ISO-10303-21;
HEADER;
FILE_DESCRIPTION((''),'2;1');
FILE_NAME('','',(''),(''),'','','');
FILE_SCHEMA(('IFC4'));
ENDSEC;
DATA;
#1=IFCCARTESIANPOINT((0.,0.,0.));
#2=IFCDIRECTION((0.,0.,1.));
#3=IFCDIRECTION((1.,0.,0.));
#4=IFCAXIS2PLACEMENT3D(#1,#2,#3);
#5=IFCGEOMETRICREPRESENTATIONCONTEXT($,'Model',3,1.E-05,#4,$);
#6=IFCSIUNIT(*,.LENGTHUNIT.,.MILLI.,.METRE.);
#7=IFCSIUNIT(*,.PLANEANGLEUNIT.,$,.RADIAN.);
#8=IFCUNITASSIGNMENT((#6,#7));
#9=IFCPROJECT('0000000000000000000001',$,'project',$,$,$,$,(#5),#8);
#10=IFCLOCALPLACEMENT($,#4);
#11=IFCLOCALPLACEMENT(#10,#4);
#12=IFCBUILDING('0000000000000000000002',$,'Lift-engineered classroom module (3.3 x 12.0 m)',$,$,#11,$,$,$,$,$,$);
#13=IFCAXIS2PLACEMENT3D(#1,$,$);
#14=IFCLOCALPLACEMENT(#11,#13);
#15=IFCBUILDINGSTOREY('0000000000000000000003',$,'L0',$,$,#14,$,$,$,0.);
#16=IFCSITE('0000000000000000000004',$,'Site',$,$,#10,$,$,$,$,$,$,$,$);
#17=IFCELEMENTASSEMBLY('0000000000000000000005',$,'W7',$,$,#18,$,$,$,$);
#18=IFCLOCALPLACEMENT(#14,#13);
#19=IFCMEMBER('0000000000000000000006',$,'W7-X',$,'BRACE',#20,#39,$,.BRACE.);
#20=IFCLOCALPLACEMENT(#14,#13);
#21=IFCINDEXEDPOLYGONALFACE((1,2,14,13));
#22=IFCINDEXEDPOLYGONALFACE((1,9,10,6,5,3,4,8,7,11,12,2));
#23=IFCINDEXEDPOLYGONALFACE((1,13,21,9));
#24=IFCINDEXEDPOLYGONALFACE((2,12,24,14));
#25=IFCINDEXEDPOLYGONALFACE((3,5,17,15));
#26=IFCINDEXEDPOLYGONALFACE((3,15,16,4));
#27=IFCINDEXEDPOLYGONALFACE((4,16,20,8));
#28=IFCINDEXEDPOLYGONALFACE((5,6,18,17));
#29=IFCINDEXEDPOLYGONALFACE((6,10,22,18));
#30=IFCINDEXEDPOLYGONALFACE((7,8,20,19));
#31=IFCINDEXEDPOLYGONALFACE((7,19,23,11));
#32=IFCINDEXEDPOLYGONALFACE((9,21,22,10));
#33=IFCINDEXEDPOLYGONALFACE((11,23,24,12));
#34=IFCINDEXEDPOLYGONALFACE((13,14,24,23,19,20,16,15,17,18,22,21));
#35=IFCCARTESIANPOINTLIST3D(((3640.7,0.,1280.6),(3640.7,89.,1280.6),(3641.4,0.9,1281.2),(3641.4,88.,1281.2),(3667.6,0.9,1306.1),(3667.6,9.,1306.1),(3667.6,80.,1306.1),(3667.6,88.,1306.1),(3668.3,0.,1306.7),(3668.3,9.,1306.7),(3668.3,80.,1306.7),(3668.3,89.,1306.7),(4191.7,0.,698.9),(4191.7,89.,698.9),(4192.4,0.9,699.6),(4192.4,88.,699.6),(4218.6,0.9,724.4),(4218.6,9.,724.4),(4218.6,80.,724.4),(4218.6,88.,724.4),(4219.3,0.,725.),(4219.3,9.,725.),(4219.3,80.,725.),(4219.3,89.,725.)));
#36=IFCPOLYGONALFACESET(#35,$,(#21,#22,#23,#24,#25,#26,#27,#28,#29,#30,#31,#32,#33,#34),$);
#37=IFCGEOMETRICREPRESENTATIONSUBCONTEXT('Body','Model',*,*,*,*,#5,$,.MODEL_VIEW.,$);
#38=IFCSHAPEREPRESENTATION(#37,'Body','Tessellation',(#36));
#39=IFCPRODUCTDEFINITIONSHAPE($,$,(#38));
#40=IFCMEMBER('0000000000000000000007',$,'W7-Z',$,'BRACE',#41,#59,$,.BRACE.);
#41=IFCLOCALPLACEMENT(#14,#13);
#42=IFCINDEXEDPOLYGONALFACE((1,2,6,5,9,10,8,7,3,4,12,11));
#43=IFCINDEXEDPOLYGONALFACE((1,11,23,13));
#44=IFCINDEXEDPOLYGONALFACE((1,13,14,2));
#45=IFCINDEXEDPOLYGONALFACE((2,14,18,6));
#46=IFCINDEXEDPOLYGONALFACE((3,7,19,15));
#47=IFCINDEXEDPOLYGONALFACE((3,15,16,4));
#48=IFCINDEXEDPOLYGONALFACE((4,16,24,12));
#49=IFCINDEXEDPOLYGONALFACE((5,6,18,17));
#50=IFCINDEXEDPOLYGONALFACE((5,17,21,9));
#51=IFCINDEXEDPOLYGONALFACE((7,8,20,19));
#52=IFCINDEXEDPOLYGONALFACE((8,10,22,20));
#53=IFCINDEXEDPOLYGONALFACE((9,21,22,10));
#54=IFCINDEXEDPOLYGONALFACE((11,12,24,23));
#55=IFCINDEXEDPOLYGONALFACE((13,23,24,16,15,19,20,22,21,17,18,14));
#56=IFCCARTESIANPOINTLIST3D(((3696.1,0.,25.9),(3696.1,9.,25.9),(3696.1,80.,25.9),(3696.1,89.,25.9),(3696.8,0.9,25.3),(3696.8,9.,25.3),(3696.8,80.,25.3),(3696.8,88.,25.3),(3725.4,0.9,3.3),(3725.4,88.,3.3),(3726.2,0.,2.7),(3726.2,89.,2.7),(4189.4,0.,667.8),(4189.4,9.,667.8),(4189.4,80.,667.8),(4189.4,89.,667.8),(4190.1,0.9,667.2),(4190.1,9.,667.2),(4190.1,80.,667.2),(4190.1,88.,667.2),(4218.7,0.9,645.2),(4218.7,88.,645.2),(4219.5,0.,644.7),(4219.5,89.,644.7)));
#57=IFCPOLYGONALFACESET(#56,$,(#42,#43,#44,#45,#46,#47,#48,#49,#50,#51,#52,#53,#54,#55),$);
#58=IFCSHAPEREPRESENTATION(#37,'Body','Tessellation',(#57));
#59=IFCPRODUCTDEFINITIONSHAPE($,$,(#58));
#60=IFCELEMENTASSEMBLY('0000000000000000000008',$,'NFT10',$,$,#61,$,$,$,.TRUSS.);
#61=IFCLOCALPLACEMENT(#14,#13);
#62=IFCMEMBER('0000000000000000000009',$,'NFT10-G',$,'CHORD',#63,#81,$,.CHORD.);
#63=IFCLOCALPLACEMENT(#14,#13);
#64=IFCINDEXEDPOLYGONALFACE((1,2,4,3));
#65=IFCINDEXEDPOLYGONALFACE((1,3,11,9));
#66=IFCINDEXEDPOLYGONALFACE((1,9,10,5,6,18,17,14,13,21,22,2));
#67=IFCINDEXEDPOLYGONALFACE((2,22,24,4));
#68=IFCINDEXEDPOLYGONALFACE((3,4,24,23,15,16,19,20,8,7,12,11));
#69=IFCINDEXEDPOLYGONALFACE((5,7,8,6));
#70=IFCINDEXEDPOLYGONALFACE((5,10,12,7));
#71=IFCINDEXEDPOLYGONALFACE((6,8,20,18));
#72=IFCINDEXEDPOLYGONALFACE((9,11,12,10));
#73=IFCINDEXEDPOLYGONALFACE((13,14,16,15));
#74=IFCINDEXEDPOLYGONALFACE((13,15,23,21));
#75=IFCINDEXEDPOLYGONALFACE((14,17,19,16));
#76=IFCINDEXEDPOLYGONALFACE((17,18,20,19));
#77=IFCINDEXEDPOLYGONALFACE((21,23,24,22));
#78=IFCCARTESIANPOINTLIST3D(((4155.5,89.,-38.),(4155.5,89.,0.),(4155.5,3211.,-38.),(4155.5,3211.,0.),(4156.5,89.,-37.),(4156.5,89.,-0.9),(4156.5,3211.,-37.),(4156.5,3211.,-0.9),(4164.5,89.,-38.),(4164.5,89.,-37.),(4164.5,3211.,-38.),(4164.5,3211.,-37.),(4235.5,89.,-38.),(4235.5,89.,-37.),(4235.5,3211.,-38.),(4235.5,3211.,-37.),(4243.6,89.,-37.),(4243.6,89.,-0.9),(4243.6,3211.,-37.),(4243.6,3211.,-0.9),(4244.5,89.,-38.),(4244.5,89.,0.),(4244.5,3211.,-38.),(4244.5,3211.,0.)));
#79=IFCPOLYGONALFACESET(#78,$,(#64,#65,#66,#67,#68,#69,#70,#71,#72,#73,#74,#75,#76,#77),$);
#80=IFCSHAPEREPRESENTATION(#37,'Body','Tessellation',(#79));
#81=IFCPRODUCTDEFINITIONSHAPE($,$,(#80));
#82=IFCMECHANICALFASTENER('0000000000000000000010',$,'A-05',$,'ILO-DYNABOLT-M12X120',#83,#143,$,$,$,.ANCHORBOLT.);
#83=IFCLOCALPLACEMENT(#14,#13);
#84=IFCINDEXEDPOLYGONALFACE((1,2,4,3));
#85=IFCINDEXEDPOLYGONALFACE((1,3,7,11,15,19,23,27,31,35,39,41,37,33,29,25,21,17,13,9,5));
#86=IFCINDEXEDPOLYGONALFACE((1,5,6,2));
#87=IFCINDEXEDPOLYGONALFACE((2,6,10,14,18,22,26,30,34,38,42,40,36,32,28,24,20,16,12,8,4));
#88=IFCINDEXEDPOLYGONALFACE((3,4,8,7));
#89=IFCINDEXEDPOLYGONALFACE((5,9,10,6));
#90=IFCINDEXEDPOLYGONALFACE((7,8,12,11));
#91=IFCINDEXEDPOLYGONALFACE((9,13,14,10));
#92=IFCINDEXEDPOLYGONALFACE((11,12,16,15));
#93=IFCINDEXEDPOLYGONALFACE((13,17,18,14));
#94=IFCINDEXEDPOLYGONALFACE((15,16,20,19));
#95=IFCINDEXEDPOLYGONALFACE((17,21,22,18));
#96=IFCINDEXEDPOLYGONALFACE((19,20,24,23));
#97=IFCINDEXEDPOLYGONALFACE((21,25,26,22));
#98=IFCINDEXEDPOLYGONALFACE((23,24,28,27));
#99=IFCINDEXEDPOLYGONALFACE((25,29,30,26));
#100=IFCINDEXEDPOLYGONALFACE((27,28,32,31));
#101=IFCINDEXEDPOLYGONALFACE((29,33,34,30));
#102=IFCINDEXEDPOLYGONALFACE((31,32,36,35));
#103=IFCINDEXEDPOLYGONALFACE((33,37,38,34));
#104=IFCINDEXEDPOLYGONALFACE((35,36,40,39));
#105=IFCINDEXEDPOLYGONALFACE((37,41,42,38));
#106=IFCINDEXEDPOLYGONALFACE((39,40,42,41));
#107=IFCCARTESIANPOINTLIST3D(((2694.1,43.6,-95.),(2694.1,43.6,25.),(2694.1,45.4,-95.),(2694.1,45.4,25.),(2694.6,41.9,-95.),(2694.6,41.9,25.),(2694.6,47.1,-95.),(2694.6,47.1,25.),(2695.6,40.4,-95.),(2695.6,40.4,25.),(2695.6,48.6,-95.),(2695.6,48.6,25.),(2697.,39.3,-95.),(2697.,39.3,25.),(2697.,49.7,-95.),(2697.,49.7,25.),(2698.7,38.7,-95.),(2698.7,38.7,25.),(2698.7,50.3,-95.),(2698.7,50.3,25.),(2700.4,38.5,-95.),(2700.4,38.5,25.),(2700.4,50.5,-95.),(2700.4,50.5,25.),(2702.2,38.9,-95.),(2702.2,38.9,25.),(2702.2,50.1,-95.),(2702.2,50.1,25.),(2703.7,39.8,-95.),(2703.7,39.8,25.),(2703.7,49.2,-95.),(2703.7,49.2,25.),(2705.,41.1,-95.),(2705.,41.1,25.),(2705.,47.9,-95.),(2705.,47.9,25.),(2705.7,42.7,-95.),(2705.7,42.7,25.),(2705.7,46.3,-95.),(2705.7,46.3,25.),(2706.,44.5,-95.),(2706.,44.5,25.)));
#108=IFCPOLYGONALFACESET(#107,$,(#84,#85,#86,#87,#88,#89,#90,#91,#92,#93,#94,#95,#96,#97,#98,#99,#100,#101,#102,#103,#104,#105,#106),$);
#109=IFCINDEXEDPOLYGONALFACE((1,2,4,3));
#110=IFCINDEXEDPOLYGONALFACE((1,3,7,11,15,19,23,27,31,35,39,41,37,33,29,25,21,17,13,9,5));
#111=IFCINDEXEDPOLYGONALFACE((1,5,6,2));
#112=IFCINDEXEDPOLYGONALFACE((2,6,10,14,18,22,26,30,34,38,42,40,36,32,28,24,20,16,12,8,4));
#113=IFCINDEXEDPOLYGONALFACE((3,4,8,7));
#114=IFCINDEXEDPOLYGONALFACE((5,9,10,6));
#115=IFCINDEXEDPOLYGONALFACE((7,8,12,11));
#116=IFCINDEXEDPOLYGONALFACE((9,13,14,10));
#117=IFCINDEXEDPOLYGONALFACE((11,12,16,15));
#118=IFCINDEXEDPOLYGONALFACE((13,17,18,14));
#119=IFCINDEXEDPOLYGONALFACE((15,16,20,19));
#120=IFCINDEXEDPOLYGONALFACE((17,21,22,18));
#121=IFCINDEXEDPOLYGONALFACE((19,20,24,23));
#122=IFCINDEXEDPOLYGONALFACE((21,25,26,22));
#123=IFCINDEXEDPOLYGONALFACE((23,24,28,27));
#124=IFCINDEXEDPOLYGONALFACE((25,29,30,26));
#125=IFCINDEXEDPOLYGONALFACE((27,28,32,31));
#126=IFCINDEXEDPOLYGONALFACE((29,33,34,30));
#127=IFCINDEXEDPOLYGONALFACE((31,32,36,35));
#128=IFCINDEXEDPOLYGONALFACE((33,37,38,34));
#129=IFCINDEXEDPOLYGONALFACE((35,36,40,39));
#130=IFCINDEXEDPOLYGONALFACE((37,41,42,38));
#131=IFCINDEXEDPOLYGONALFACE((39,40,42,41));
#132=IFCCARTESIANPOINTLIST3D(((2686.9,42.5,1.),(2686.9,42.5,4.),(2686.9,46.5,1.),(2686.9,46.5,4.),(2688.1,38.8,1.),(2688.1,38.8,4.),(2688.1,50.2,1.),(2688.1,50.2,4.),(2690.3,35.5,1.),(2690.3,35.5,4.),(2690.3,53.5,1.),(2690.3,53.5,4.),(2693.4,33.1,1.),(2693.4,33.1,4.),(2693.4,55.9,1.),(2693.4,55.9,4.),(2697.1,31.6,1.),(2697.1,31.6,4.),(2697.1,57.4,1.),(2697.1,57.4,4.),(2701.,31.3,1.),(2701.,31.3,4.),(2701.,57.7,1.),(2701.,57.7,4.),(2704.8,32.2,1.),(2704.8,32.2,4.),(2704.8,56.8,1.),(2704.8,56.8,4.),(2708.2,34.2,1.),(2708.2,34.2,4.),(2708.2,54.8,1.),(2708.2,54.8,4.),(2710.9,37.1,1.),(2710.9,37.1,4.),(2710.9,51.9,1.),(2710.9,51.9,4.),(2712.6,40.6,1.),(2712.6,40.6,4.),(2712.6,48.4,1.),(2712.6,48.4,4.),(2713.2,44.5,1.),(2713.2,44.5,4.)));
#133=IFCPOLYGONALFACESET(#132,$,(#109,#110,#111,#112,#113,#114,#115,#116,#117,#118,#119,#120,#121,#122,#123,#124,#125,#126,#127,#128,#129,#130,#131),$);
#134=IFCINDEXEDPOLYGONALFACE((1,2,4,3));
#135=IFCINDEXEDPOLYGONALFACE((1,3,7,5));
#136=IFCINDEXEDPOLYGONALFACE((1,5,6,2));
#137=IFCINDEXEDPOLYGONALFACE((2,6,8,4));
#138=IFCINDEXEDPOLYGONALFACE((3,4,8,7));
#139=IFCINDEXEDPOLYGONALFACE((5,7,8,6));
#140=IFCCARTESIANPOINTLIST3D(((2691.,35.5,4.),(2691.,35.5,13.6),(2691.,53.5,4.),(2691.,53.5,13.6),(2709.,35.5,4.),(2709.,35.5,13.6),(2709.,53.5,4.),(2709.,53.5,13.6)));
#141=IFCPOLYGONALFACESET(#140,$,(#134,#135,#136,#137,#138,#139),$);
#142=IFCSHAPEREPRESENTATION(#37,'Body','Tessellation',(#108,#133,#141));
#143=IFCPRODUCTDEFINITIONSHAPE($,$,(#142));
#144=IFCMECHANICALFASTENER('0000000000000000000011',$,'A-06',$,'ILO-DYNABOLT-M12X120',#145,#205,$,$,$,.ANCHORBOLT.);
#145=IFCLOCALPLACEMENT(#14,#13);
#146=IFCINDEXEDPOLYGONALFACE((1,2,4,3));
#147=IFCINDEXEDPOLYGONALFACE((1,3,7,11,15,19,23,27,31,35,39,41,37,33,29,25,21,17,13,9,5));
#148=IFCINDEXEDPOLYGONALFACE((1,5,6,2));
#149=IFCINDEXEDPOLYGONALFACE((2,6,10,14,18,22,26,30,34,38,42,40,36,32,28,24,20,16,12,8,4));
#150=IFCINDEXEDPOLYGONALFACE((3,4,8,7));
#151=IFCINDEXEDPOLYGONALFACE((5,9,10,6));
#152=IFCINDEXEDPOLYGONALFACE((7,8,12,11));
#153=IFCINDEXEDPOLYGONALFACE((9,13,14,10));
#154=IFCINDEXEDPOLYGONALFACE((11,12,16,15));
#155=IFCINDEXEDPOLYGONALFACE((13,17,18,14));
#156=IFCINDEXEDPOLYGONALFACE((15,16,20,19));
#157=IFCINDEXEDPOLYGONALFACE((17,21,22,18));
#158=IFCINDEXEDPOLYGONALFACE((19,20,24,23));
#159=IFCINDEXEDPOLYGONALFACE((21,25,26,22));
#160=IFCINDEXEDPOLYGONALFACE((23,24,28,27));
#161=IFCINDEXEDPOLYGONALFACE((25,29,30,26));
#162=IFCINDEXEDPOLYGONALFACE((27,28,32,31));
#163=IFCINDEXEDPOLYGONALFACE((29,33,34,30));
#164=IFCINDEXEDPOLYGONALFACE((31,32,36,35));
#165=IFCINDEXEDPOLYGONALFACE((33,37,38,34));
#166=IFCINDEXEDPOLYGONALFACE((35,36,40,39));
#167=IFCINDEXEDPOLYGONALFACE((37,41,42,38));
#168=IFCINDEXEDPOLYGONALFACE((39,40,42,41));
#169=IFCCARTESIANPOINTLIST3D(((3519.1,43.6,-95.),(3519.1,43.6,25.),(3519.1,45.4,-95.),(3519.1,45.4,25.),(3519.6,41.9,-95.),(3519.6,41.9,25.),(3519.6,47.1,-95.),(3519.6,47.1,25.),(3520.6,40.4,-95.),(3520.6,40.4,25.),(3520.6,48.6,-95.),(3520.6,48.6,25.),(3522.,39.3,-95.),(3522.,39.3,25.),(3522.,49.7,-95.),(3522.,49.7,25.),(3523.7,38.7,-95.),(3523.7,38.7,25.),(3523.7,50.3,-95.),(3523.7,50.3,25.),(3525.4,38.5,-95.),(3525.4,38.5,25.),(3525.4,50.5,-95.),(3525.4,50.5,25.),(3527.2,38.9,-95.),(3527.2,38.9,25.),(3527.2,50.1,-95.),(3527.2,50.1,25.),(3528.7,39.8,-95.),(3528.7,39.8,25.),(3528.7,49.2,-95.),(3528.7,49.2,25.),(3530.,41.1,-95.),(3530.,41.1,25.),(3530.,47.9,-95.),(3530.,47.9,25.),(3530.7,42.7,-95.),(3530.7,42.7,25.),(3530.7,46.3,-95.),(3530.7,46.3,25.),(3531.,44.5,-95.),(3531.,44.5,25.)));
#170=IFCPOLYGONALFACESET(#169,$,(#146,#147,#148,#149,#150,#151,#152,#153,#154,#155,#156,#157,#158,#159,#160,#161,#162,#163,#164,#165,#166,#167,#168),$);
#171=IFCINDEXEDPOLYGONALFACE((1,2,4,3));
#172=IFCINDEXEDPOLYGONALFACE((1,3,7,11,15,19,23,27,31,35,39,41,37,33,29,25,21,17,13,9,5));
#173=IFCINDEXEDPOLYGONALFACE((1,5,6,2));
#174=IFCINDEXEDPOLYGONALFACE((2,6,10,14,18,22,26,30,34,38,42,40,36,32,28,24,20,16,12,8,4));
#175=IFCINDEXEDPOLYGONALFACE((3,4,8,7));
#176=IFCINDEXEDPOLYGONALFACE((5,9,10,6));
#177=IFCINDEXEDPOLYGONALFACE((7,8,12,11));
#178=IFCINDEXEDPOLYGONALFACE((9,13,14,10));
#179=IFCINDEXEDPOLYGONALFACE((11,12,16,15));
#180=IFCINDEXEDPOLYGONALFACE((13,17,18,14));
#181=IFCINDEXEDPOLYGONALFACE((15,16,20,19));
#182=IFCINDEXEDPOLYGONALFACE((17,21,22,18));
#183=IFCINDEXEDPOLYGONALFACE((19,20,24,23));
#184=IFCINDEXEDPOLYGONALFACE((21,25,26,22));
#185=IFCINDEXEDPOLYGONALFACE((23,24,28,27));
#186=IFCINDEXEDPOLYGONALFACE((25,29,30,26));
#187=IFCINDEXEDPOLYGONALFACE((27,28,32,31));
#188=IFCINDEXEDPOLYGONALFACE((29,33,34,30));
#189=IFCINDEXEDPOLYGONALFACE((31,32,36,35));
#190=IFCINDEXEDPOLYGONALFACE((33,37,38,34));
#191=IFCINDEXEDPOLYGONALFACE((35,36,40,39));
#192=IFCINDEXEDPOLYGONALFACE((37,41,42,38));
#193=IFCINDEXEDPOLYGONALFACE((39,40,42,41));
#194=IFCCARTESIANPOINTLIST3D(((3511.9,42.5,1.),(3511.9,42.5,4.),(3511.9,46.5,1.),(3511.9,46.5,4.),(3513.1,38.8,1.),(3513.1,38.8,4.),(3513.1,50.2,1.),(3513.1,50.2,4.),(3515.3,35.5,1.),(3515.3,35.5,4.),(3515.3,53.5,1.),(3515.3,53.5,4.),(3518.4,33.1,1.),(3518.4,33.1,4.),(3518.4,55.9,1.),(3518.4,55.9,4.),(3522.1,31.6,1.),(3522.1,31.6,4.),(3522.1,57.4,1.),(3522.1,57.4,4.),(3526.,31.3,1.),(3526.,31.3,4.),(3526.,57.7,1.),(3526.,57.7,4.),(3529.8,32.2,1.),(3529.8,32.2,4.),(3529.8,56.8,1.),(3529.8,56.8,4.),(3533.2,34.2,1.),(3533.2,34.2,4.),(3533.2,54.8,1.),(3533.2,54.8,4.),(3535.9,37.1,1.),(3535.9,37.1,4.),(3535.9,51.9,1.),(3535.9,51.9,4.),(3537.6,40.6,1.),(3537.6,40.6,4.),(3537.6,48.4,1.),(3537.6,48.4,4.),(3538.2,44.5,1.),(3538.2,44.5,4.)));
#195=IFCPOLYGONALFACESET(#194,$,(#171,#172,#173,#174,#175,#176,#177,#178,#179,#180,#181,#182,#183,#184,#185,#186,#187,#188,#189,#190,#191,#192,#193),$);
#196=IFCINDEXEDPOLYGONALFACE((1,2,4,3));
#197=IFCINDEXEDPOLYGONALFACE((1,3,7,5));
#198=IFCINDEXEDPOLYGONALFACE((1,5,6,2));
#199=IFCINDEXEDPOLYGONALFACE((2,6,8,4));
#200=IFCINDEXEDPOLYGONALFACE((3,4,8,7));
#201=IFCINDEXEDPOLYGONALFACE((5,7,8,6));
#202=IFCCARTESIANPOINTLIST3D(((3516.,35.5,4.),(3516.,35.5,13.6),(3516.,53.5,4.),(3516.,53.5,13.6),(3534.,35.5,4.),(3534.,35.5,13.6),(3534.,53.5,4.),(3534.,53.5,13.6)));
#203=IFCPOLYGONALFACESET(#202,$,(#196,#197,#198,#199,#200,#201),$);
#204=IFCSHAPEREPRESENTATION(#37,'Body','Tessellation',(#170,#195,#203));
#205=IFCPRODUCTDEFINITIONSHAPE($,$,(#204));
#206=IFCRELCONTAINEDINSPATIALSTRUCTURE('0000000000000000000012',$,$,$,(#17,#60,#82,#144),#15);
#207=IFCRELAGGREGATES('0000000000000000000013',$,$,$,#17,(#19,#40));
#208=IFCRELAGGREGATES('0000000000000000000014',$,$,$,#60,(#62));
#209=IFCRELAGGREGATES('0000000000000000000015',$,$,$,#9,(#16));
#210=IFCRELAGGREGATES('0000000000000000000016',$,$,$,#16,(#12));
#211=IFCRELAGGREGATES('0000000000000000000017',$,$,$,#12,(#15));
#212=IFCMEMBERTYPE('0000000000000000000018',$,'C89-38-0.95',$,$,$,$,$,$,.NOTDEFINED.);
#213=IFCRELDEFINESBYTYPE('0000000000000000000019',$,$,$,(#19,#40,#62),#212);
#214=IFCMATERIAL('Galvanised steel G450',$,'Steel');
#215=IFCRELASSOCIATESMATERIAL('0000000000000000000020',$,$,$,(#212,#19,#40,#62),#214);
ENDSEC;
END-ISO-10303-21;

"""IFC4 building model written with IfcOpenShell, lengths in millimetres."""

from ifc_helpers import new_model, si_unit, frame, origin, origin_with_axes, origin_2d, place, context, subcontext, project, spatial, rectangle, circle, c_section, extrude, material, material_profile, profile_set, profile_usage, type_object, element, aggregate, save


model = new_model("IFC4")

# Units and contexts
model_context = context("Model", 3, precision=1e-05, world=origin_with_axes())
body_context = subcontext(model_context, "Body", "Model", "MODEL_VIEW")
ifc_project = project(units=[si_unit("LENGTHUNIT", "METRE", prefix="MILLI"), si_unit("PLANEANGLEUNIT", "RADIAN")], contexts=[model_context])

# Site, building, storey
site_placement = place(None, origin_with_axes())
site = spatial("IfcSite", under=ifc_project, at=site_placement, Name="Site")
building_placement = place(site_placement, origin_with_axes())
building = spatial("IfcBuilding", under=site, at=building_placement, Name="Lift-engineered classroom module (3.3 x 12.0 m)")
storey_placement = place(building_placement, origin())
storey = spatial("IfcBuildingStorey", under=building, at=storey_placement, Name="L0", Elevation=0.0)

# Element assembly, members
assembly_1_placement = place(storey_placement, frame((900.0, 44.5, 0.0)))
assembly_1 = element("IfcElementAssembly", 1, at=assembly_1_placement, inside=storey, Name="W7")
ifc_material = material(Name="Galvanised steel G450", Category="Steel")
ifc_material_profile = material_profile(ifc_material, c_section(Depth=89.0, Width=38.0, WallThickness=0.9, Girth=9.0, at=origin_2d()), Name="C89-38-0.95")
ifc_profile_set = profile_set([ifc_material_profile], Name="C89-38-0.95")
ifc_profile_usage = profile_usage(ifc_profile_set)
member_type = type_object("IfcMemberType", Name="C89-38-0.95", PredefinedType="NOTDEFINED", material=ifc_profile_set)
member_1_placement = place(assembly_1_placement, frame((2754.5, 0.0, 1293.6), z_axis=(0.687721, 0.0, -0.725975), x_axis=(0.725975, 0.0, 0.687721)))
member_1 = element("IfcMember", 2, at=member_1_placement, type_object=member_type, material=ifc_profile_usage, Name="W7-X", ObjectType="BRACE", PredefinedType="BRACE", context=body_context, shape_type="SweptSolid", body=[
    extrude(c_section(Depth=89.0, Width=38.0, WallThickness=0.9, Girth=9.0, at=origin_2d()), origin(), (0.0, 0.0, 1.0), 801.2),
])
member_2_placement = place(assembly_1_placement, frame((2811.1, 0.0, 14.3), z_axis=(0.609305, 0.0, 0.792936), x_axis=(-0.792936, 0.0, 0.609305)))
member_2 = element("IfcMember", 3, at=member_2_placement, type_object=member_type, material=ifc_profile_usage, Name="W7-Z", ObjectType="BRACE", PredefinedType="BRACE", context=body_context, shape_type="SweptSolid", body=[
    extrude(c_section(Depth=89.0, Width=38.0, WallThickness=0.9, Girth=9.0, at=origin_2d()), origin(), (0.0, 0.0, 1.0), 809.6),
])
aggregate(assembly_1, [member_1, member_2])

# Element assembly, member
assembly_2_placement = place(storey_placement, frame((4200.0, 89.0, -300.0)))
assembly_2 = element("IfcElementAssembly", 4, at=assembly_2_placement, inside=storey, Name="NFT10", PredefinedType="TRUSS")
member_3_placement = place(assembly_2_placement, frame((0.0, 0.0, 281.0), z_axis=(0.0, 1.0, 0.0), x_axis=(0.0, 0.0, -1.0)))
member_3 = element("IfcMember", 5, at=member_3_placement, type_object=member_type, material=ifc_profile_usage, Name="NFT10-G", ObjectType="CHORD", PredefinedType="CHORD", context=body_context, shape_type="SweptSolid", body=[
    extrude(c_section(Depth=89.0, Width=38.0, WallThickness=0.9, Girth=9.0, at=origin_2d()), origin(), (0.0, 0.0, 1.0), 3122.0),
])
aggregate(assembly_2, [member_3])

# Mechanical fasteners
for number, where, z_axis, x_axis, name in (
    (6, (2700.0, 44.5, 0.0), (0.0, 0.0, 1.0), (1.0, 0.0, 0.0), "A-05"),
    (7, (3525.0, 44.5, 0.0), (0.0, 0.0, 1.0), (1.0, 0.0, 0.0), "A-06"),
):
    element("IfcMechanicalFastener", number, at=place(None, frame(where, z_axis=z_axis, x_axis=x_axis)), inside=storey, Name=name, ObjectType="ILO-DYNABOLT-M12X120", PredefinedType="ANCHORBOLT", context=body_context, shape_type="SweptSolid", body=[
        extrude(circle(Radius=6.0, at=origin_2d()), frame((0.0, 0.0, -95.0), z_axis=(0.0, 0.0, 1.0), x_axis=(1.0, 0.0, 0.0)), (0.0, 0.0, 1.0), 120.0),
        extrude(circle(Radius=13.2, at=origin_2d()), frame((0.0, 0.0, 1.0), z_axis=(0.0, 0.0, 1.0), x_axis=(1.0, 0.0, 0.0)), (0.0, 0.0, 1.0), 3.0),
        extrude(rectangle(XDim=18.0, YDim=18.0, at=origin_2d()), frame((0.0, 0.0, 4.0), z_axis=(0.0, 0.0, 1.0), x_axis=(1.0, 0.0, 0.0)), (0.0, 0.0, 1.0), 9.6),
    ])

save(model, "model.ifc")
